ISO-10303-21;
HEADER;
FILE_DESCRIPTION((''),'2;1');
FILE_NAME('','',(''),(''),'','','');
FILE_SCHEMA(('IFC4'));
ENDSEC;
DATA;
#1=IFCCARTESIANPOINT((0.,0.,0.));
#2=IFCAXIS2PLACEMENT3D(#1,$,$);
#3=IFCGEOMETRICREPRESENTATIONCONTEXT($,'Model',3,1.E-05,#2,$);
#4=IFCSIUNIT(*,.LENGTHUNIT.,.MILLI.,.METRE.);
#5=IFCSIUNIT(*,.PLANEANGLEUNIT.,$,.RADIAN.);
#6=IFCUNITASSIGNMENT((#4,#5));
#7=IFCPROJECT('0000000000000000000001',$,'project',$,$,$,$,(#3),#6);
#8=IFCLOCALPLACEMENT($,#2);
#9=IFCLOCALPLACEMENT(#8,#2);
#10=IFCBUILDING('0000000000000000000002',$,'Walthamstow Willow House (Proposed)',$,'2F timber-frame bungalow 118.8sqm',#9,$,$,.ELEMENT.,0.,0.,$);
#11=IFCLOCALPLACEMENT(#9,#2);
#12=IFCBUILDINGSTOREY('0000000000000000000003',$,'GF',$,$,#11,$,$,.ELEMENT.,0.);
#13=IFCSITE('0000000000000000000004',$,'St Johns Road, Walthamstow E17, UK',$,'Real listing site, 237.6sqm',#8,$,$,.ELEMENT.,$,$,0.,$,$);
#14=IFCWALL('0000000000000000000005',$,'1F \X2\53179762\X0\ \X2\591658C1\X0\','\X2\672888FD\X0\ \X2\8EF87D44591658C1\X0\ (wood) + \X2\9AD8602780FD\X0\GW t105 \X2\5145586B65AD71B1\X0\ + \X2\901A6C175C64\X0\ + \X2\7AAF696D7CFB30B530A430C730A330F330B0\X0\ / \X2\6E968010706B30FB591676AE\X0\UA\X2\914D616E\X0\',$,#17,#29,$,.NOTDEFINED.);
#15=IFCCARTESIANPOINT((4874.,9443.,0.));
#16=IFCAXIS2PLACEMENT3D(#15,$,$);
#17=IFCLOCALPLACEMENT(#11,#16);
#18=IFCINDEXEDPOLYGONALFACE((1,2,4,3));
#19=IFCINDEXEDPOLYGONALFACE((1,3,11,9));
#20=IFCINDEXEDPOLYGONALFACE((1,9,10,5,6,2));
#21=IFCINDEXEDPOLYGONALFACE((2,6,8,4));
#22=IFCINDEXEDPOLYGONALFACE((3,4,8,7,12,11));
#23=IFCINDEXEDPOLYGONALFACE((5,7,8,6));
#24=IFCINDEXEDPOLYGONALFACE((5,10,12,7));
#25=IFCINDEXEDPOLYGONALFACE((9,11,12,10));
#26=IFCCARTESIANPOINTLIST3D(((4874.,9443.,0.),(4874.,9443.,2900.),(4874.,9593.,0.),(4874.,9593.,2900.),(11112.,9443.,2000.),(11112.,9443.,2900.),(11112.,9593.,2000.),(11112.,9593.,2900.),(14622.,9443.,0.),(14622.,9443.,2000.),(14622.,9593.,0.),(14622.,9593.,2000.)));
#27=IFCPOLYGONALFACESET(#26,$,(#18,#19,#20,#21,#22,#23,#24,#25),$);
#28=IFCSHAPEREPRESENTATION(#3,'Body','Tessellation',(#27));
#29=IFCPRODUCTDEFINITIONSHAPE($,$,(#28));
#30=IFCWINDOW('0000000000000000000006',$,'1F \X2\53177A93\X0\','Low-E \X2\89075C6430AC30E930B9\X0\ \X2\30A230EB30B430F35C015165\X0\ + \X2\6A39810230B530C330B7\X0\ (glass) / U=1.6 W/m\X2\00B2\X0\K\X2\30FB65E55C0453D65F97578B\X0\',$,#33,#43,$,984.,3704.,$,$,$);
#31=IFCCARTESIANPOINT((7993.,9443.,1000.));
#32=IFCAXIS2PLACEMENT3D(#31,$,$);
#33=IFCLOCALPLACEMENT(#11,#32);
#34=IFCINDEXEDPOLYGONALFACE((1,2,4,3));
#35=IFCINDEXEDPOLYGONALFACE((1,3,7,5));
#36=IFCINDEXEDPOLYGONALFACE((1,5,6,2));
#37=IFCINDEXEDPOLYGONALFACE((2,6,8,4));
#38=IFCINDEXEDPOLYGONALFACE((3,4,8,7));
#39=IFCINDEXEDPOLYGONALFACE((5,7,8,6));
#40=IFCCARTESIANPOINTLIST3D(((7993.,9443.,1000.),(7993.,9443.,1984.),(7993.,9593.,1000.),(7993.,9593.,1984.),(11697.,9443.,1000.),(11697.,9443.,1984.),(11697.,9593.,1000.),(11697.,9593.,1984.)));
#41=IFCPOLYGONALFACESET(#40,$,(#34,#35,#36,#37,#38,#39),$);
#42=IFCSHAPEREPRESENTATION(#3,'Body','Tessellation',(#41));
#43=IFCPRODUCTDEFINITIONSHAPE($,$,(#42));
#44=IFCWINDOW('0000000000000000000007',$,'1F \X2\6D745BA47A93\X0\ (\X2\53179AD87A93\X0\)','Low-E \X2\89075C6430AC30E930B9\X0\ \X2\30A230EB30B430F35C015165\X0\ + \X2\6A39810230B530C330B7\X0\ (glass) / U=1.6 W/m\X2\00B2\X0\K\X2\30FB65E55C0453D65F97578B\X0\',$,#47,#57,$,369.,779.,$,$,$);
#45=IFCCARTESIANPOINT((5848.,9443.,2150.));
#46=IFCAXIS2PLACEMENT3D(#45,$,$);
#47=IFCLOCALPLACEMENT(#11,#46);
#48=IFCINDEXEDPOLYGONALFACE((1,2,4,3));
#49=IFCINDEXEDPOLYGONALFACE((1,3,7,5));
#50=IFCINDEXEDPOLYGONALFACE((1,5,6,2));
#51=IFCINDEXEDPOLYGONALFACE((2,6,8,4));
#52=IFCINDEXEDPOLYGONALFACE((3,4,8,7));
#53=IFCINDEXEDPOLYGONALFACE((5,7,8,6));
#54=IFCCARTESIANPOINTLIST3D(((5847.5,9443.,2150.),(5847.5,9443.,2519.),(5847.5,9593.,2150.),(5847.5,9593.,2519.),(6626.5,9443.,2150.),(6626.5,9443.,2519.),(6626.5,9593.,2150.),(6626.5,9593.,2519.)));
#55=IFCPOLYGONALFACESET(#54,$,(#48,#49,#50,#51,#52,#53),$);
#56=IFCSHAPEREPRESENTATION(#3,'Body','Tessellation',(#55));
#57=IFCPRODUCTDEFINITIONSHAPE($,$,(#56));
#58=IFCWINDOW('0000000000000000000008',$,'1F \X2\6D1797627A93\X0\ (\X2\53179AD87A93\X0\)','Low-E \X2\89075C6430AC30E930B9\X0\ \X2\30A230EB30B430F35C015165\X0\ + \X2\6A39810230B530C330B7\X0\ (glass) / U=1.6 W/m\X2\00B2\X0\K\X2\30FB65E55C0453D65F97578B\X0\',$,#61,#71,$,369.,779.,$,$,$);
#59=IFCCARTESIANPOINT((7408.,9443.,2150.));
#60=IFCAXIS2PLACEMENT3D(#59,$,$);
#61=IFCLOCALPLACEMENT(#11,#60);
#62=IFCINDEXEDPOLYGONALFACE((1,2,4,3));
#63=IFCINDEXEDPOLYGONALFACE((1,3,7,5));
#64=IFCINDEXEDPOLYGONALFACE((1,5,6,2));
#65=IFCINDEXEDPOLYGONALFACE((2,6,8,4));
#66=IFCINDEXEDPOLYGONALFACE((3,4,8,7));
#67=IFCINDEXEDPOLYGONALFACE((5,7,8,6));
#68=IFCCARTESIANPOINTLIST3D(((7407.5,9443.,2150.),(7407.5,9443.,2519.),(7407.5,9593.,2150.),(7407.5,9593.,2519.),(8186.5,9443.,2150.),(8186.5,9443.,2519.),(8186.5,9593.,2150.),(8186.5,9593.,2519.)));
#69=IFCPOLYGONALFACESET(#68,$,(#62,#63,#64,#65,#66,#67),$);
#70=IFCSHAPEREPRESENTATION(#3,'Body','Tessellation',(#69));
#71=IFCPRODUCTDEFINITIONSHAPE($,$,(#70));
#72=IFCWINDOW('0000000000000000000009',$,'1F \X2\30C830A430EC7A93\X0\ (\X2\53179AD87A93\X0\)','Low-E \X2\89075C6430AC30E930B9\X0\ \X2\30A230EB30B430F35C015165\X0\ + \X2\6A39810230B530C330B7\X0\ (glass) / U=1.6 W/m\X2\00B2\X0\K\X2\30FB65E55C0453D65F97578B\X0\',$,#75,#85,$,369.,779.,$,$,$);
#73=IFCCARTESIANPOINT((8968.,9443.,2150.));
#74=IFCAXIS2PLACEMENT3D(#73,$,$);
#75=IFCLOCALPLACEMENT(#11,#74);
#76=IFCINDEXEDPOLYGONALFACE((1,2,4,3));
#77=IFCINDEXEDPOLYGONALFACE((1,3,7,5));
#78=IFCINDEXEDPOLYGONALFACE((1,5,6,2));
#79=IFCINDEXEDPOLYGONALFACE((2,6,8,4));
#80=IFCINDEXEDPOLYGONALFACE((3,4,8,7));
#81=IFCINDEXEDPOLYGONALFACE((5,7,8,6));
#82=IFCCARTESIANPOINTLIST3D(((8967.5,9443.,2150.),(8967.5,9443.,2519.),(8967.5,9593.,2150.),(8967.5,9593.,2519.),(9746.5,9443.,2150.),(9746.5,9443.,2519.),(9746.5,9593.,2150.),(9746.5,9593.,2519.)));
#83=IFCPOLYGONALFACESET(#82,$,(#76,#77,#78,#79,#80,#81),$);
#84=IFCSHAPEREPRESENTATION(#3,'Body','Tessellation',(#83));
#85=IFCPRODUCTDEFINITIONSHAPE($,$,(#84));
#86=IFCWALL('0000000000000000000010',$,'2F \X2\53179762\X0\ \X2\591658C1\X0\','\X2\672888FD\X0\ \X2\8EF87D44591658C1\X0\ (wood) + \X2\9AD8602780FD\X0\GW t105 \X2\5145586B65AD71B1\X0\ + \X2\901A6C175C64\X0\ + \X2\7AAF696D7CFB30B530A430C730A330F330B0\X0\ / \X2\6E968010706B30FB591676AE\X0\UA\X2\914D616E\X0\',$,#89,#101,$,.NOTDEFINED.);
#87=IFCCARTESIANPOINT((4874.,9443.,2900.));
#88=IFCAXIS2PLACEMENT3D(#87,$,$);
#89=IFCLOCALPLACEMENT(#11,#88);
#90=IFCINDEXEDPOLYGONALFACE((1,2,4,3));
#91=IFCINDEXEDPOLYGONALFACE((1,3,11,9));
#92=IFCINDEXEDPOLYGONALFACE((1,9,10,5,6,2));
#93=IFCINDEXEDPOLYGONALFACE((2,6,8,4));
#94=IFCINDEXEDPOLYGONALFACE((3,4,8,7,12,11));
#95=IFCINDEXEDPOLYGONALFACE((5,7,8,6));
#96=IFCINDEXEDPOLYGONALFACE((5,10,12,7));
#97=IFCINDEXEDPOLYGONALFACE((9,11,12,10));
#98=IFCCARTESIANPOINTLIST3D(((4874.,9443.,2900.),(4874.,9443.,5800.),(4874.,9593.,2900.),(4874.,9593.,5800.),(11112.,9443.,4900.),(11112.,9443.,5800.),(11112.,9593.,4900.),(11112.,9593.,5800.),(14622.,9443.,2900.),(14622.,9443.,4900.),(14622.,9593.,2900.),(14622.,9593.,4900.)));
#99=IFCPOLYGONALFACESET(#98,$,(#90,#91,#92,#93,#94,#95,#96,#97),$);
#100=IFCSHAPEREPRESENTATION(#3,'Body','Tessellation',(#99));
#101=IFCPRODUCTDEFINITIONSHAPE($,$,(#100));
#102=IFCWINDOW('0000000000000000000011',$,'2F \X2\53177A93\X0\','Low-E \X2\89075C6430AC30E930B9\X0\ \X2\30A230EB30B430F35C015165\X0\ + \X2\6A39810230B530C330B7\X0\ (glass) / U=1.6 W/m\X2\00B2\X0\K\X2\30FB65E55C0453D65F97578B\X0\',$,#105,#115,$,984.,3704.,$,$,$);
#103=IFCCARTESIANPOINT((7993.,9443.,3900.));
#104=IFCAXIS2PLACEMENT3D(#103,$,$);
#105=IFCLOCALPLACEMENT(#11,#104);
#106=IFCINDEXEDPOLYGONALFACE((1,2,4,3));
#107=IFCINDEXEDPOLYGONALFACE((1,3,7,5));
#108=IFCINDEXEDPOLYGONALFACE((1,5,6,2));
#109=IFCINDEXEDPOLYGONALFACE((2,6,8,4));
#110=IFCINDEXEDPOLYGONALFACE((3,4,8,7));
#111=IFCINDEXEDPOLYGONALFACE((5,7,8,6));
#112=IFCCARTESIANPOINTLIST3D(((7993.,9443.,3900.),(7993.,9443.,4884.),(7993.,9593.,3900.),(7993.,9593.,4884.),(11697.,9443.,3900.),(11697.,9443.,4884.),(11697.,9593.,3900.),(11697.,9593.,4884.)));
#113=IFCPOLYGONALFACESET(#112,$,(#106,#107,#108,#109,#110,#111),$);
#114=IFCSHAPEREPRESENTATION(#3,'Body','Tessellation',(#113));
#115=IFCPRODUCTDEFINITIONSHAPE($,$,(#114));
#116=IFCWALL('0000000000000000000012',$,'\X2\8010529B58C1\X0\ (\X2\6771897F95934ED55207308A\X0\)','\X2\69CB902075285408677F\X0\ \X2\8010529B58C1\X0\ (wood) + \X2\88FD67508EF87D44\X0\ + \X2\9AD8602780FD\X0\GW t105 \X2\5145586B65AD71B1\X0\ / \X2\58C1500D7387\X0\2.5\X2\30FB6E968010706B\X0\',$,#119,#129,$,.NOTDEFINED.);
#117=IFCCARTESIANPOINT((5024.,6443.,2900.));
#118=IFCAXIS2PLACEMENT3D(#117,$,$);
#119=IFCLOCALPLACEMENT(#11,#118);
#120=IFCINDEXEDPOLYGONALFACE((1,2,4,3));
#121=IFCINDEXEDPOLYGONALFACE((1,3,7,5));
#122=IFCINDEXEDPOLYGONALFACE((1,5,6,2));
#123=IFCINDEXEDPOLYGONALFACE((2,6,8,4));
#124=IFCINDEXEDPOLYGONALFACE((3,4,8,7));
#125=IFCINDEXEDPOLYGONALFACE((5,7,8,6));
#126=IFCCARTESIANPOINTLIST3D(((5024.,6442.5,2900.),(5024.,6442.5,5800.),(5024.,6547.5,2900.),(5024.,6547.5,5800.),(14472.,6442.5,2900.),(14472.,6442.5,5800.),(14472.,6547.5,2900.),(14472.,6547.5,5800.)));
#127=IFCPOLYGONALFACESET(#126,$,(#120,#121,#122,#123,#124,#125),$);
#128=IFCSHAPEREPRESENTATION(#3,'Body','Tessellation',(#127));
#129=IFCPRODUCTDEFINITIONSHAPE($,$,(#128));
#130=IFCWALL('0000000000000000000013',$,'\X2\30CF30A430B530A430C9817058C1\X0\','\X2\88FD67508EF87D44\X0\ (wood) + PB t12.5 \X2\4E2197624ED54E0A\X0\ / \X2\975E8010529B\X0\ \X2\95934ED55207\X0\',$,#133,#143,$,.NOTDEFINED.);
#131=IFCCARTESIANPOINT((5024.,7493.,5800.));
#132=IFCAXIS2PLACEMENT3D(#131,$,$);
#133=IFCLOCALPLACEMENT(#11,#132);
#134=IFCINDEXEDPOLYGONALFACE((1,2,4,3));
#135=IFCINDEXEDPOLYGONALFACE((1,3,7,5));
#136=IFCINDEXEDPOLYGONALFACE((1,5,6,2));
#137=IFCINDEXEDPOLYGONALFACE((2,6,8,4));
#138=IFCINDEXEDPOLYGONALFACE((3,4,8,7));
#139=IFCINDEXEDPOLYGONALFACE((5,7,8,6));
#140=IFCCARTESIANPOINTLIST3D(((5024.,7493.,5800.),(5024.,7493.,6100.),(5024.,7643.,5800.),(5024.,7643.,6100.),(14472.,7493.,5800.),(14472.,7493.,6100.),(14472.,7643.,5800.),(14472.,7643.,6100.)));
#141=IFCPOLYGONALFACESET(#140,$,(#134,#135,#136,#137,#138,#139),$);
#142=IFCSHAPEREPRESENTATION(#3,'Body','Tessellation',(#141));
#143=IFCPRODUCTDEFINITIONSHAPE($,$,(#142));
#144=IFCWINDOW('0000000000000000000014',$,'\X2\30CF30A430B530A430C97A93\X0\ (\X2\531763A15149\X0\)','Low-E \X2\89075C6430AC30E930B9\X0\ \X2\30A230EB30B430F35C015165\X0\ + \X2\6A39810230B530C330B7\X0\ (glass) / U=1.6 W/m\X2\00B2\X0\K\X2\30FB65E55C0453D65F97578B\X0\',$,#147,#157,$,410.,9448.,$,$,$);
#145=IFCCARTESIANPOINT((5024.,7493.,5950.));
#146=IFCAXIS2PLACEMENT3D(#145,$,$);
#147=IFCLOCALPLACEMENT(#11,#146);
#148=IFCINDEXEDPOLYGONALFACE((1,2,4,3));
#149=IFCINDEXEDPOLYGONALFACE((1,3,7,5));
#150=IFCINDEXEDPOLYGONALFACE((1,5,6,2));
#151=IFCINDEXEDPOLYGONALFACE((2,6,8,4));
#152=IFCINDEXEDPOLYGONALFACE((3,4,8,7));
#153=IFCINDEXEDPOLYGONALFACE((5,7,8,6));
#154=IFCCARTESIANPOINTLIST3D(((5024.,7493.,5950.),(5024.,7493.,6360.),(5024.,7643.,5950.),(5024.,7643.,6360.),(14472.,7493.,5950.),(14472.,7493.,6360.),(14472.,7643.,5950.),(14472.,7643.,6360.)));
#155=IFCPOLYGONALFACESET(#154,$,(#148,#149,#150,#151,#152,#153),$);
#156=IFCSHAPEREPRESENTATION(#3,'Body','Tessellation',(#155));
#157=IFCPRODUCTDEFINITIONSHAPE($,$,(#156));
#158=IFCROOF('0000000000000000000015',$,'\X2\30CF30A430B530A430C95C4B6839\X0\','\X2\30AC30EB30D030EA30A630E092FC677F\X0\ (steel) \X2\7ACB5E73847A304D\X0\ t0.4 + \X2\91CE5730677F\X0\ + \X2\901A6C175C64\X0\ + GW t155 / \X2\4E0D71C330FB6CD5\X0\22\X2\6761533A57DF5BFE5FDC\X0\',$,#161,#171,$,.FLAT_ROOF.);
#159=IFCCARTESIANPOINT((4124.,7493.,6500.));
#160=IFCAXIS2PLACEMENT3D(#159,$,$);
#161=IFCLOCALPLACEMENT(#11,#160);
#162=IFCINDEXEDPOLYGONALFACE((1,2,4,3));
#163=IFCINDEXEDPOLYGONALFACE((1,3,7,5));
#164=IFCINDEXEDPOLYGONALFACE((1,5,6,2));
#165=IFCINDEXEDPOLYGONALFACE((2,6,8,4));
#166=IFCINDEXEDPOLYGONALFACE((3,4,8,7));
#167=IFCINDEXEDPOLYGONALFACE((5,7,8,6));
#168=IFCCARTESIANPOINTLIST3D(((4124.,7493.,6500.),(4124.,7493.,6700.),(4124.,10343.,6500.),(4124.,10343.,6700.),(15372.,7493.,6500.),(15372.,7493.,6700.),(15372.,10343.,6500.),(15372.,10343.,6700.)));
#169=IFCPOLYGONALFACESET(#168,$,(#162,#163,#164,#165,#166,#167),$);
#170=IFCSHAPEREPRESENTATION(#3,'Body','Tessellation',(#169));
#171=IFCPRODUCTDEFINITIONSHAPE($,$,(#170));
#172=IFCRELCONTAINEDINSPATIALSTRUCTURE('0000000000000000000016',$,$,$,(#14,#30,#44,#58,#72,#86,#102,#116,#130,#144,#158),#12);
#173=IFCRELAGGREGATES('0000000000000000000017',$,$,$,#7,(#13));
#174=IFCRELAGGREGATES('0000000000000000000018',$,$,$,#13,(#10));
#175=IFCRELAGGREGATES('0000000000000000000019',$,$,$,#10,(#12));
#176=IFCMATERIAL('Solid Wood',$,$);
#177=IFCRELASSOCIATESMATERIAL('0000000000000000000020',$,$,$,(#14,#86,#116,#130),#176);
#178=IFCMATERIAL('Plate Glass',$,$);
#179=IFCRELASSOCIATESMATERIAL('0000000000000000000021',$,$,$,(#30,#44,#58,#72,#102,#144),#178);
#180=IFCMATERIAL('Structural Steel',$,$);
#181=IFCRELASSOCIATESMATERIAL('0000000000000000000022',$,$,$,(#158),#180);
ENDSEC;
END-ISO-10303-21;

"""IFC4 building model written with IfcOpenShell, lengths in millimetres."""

from ifc_helpers import new_model, si_unit, frame, frame_2d, origin, place, context, project, spatial, rectangle, extrude, material, element, fill, save


model = new_model("IFC4")

# Units and contexts
model_context = context("Model", 3, precision=1e-05, world=origin())
ifc_project = project(units=[si_unit("LENGTHUNIT", "METRE", prefix="MILLI"), si_unit("PLANEANGLEUNIT", "RADIAN")], contexts=[model_context])

# Site, building, storey
site_placement = place(None, origin())
site = spatial("IfcSite", under=ifc_project, at=site_placement, Name="St Johns Road, Walthamstow E17, UK", ObjectType="Real listing site, 237.6sqm", CompositionType="ELEMENT", RefElevation=0.0)
building_placement = place(site_placement, origin())
building = spatial("IfcBuilding", under=site, at=building_placement, Name="Walthamstow Willow House (Proposed)", ObjectType="2F timber-frame bungalow 118.8sqm", CompositionType="ELEMENT", ElevationOfRefHeight=0.0, ElevationOfTerrain=0.0)
storey_placement = place(building_placement, origin())
storey = spatial("IfcBuildingStorey", under=building, at=storey_placement, Name="GF", CompositionType="ELEMENT", Elevation=0.0)

# Wall, openings, windows
ifc_material_1 = material(Name="Solid Wood")
wall_1_placement = place(storey_placement, frame((4874.0, 9443.0, 0.0)))
wall_1 = element("IfcWall", 1, at=wall_1_placement, inside=storey, material=ifc_material_1, Name="1F 北面 外壁", Description="木製 軸組外壁 (wood) + 高性能GW t105 充填断熱 + 通気層 + 窯業系サイディング / 準耐火・外皮UA配慮", PredefinedType="NOTDEFINED", context=model_context, shape_type="SweptSolid", body=[
    extrude(rectangle(XDim=9748.0, YDim=150.0, at=frame_2d((4874.0, 75.0))), frame((4874.0, 9443.0, 0.0)), (0.0, 0.0, 1.0), 2900.0),
])
opening_1_placement = place(storey_placement, frame((7993.0, 9443.0, 1000.0)))
opening_1 = element("IfcOpeningElement", 2, at=opening_1_placement, cuts=wall_1, PredefinedType="NOTDEFINED", context=model_context, shape_type="SweptSolid", body=[
    extrude(rectangle(XDim=3704.0, YDim=150.0, at=frame_2d((1852.0, 75.0))), frame((7993.0, 9443.0, 1000.0)), (0.0, 0.0, 1.0), 984.0),
])
opening_2_placement = place(storey_placement, frame((5848.0, 9443.0, 2150.0)))
opening_2 = element("IfcOpeningElement", 3, at=opening_2_placement, cuts=wall_1, PredefinedType="NOTDEFINED", context=model_context, shape_type="SweptSolid", body=[
    extrude(rectangle(XDim=779.0, YDim=150.0, at=frame_2d((389.0, 75.0))), frame((5848.0, 9443.0, 2150.0)), (0.0, 0.0, 1.0), 369.0),
])
opening_3_placement = place(storey_placement, frame((7408.0, 9443.0, 2150.0)))
opening_3 = element("IfcOpeningElement", 4, at=opening_3_placement, cuts=wall_1, PredefinedType="NOTDEFINED", context=model_context, shape_type="SweptSolid", body=[
    extrude(rectangle(XDim=779.0, YDim=150.0, at=frame_2d((389.0, 75.0))), frame((7408.0, 9443.0, 2150.0)), (0.0, 0.0, 1.0), 369.0),
])
opening_4_placement = place(storey_placement, frame((8968.0, 9443.0, 2150.0)))
opening_4 = element("IfcOpeningElement", 5, at=opening_4_placement, cuts=wall_1, PredefinedType="NOTDEFINED", context=model_context, shape_type="SweptSolid", body=[
    extrude(rectangle(XDim=779.0, YDim=150.0, at=frame_2d((389.0, 75.0))), frame((8968.0, 9443.0, 2150.0)), (0.0, 0.0, 1.0), 369.0),
])
ifc_material_2 = material(Name="Plate Glass")
window_1_placement = place(storey_placement, frame((7993.0, 9443.0, 1000.0)))
window_1 = element("IfcWindow", 6, at=window_1_placement, inside=storey, material=ifc_material_2, Name="1F 北窓", Description="Low-E 複層ガラス アルゴン封入 + 樹脂サッシ (glass) / U=1.6 W/m²K・日射取得型", OverallHeight=984.0, OverallWidth=3704.0, context=model_context, shape_type="SweptSolid", body=[
    extrude(rectangle(XDim=3704.0, YDim=150.0, at=frame_2d((1852.0, 75.0))), frame((7993.0, 9443.0, 1000.0)), (0.0, 0.0, 1.0), 984.0),
])
fill(opening_1, window_1)
window_2_placement = place(storey_placement, frame((5848.0, 9443.0, 2150.0)))
window_2 = element("IfcWindow", 7, at=window_2_placement, inside=storey, material=ifc_material_2, Name="1F 浴室窓 (北高窓)", Description="Low-E 複層ガラス アルゴン封入 + 樹脂サッシ (glass) / U=1.6 W/m²K・日射取得型", OverallHeight=369.0, OverallWidth=779.0, context=model_context, shape_type="SweptSolid", body=[
    extrude(rectangle(XDim=779.0, YDim=150.0, at=frame_2d((389.0, 75.0))), frame((5848.0, 9443.0, 2150.0)), (0.0, 0.0, 1.0), 369.0),
])
fill(opening_2, window_2)
window_3_placement = place(storey_placement, frame((7408.0, 9443.0, 2150.0)))
window_3 = element("IfcWindow", 8, at=window_3_placement, inside=storey, material=ifc_material_2, Name="1F 洗面窓 (北高窓)", Description="Low-E 複層ガラス アルゴン封入 + 樹脂サッシ (glass) / U=1.6 W/m²K・日射取得型", OverallHeight=369.0, OverallWidth=779.0, context=model_context, shape_type="SweptSolid", body=[
    extrude(rectangle(XDim=779.0, YDim=150.0, at=frame_2d((389.0, 75.0))), frame((7408.0, 9443.0, 2150.0)), (0.0, 0.0, 1.0), 369.0),
])
fill(opening_3, window_3)
window_4_placement = place(storey_placement, frame((8968.0, 9443.0, 2150.0)))
window_4 = element("IfcWindow", 9, at=window_4_placement, inside=storey, material=ifc_material_2, Name="1F トイレ窓 (北高窓)", Description="Low-E 複層ガラス アルゴン封入 + 樹脂サッシ (glass) / U=1.6 W/m²K・日射取得型", OverallHeight=369.0, OverallWidth=779.0, context=model_context, shape_type="SweptSolid", body=[
    extrude(rectangle(XDim=779.0, YDim=150.0, at=frame_2d((389.0, 75.0))), frame((8968.0, 9443.0, 2150.0)), (0.0, 0.0, 1.0), 369.0),
])
fill(opening_4, window_4)

# Wall, opening, window
wall_2_placement = place(storey_placement, frame((4874.0, 9443.0, 2900.0)))
wall_2 = element("IfcWall", 10, at=wall_2_placement, inside=storey, material=ifc_material_1, Name="2F 北面 外壁", Description="木製 軸組外壁 (wood) + 高性能GW t105 充填断熱 + 通気層 + 窯業系サイディング / 準耐火・外皮UA配慮", PredefinedType="NOTDEFINED", context=model_context, shape_type="SweptSolid", body=[
    extrude(rectangle(XDim=9748.0, YDim=150.0, at=frame_2d((4874.0, 75.0))), frame((4874.0, 9443.0, 2900.0)), (0.0, 0.0, 1.0), 2900.0),
])
opening_5_placement = place(storey_placement, frame((7993.0, 9443.0, 3900.0)))
opening_5 = element("IfcOpeningElement", 11, at=opening_5_placement, cuts=wall_2, PredefinedType="NOTDEFINED", context=model_context, shape_type="SweptSolid", body=[
    extrude(rectangle(XDim=3704.0, YDim=150.0, at=frame_2d((1852.0, 75.0))), frame((7993.0, 9443.0, 3900.0)), (0.0, 0.0, 1.0), 984.0),
])
window_5_placement = place(storey_placement, frame((7993.0, 9443.0, 3900.0)))
window_5 = element("IfcWindow", 12, at=window_5_placement, inside=storey, material=ifc_material_2, Name="2F 北窓", Description="Low-E 複層ガラス アルゴン封入 + 樹脂サッシ (glass) / U=1.6 W/m²K・日射取得型", OverallHeight=984.0, OverallWidth=3704.0, context=model_context, shape_type="SweptSolid", body=[
    extrude(rectangle(XDim=3704.0, YDim=150.0, at=frame_2d((1852.0, 75.0))), frame((7993.0, 9443.0, 3900.0)), (0.0, 0.0, 1.0), 984.0),
])
fill(opening_5, window_5)

# Wall
wall_3_placement = place(storey_placement, frame((5024.0, 6443.0, 2900.0)))
element("IfcWall", 13, at=wall_3_placement, inside=storey, material=ifc_material_1, Name="耐力壁 (東西間仕切り)", Description="構造用合板 耐力壁 (wood) + 製材軸組 + 高性能GW t105 充填断熱 / 壁倍率2.5・準耐火", PredefinedType="NOTDEFINED", context=model_context, shape_type="SweptSolid", body=[
    extrude(rectangle(XDim=9448.0, YDim=105.0, at=frame_2d((4724.0, 52.0))), frame((5024.0, 6443.0, 2900.0)), (0.0, 0.0, 1.0), 2900.0),
])

# Wall, opening, window
wall_4_placement = place(storey_placement, frame((5024.0, 7493.0, 5800.0)))
wall_4 = element("IfcWall", 14, at=wall_4_placement, inside=storey, material=ifc_material_1, Name="ハイサイド腰壁", Description="製材軸組 (wood) + PB t12.5 両面仕上 / 非耐力 間仕切", PredefinedType="NOTDEFINED", context=model_context, shape_type="SweptSolid", body=[
    extrude(rectangle(XDim=9448.0, YDim=150.0, at=frame_2d((4724.0, 75.0))), frame((5024.0, 7493.0, 5800.0)), (0.0, 0.0, 1.0), 700.0),
])
opening_6_placement = place(storey_placement, frame((5024.0, 7493.0, 5950.0)))
opening_6 = element("IfcOpeningElement", 15, at=opening_6_placement, cuts=wall_4, PredefinedType="NOTDEFINED", context=model_context, shape_type="SweptSolid", body=[
    extrude(rectangle(XDim=9448.0, YDim=150.0, at=frame_2d((4724.0, 75.0))), frame((5024.0, 7493.0, 5950.0)), (0.0, 0.0, 1.0), 410.0),
])
window_6_placement = place(storey_placement, frame((5024.0, 7493.0, 5950.0)))
window_6 = element("IfcWindow", 16, at=window_6_placement, inside=storey, material=ifc_material_2, Name="ハイサイド窓 (北採光)", Description="Low-E 複層ガラス アルゴン封入 + 樹脂サッシ (glass) / U=1.6 W/m²K・日射取得型", OverallHeight=410.0, OverallWidth=9448.0, context=model_context, shape_type="SweptSolid", body=[
    extrude(rectangle(XDim=9448.0, YDim=150.0, at=frame_2d((4724.0, 75.0))), frame((5024.0, 7493.0, 5950.0)), (0.0, 0.0, 1.0), 410.0),
])
fill(opening_6, window_6)

# Roof
ifc_material_3 = material(Name="Structural Steel")
roof_placement = place(storey_placement, frame((4124.0, 7493.0, 6500.0)))
element("IfcRoof", 17, at=roof_placement, inside=storey, material=ifc_material_3, Name="ハイサイド屋根", Description="ガルバリウム鋼板 (steel) 立平葺き t0.4 + 野地板 + 通気層 + GW t155 / 不燃・法22条区域対応", PredefinedType="FLAT_ROOF", context=model_context, shape_type="SweptSolid", body=[
    extrude(rectangle(XDim=11248.0, YDim=2850.0, at=frame_2d((5624.0, 1425.0))), frame((4124.0, 7493.0, 6500.0)), (0.0, 0.0, 1.0), 200.0),
])

save(model, "model.ifc")
